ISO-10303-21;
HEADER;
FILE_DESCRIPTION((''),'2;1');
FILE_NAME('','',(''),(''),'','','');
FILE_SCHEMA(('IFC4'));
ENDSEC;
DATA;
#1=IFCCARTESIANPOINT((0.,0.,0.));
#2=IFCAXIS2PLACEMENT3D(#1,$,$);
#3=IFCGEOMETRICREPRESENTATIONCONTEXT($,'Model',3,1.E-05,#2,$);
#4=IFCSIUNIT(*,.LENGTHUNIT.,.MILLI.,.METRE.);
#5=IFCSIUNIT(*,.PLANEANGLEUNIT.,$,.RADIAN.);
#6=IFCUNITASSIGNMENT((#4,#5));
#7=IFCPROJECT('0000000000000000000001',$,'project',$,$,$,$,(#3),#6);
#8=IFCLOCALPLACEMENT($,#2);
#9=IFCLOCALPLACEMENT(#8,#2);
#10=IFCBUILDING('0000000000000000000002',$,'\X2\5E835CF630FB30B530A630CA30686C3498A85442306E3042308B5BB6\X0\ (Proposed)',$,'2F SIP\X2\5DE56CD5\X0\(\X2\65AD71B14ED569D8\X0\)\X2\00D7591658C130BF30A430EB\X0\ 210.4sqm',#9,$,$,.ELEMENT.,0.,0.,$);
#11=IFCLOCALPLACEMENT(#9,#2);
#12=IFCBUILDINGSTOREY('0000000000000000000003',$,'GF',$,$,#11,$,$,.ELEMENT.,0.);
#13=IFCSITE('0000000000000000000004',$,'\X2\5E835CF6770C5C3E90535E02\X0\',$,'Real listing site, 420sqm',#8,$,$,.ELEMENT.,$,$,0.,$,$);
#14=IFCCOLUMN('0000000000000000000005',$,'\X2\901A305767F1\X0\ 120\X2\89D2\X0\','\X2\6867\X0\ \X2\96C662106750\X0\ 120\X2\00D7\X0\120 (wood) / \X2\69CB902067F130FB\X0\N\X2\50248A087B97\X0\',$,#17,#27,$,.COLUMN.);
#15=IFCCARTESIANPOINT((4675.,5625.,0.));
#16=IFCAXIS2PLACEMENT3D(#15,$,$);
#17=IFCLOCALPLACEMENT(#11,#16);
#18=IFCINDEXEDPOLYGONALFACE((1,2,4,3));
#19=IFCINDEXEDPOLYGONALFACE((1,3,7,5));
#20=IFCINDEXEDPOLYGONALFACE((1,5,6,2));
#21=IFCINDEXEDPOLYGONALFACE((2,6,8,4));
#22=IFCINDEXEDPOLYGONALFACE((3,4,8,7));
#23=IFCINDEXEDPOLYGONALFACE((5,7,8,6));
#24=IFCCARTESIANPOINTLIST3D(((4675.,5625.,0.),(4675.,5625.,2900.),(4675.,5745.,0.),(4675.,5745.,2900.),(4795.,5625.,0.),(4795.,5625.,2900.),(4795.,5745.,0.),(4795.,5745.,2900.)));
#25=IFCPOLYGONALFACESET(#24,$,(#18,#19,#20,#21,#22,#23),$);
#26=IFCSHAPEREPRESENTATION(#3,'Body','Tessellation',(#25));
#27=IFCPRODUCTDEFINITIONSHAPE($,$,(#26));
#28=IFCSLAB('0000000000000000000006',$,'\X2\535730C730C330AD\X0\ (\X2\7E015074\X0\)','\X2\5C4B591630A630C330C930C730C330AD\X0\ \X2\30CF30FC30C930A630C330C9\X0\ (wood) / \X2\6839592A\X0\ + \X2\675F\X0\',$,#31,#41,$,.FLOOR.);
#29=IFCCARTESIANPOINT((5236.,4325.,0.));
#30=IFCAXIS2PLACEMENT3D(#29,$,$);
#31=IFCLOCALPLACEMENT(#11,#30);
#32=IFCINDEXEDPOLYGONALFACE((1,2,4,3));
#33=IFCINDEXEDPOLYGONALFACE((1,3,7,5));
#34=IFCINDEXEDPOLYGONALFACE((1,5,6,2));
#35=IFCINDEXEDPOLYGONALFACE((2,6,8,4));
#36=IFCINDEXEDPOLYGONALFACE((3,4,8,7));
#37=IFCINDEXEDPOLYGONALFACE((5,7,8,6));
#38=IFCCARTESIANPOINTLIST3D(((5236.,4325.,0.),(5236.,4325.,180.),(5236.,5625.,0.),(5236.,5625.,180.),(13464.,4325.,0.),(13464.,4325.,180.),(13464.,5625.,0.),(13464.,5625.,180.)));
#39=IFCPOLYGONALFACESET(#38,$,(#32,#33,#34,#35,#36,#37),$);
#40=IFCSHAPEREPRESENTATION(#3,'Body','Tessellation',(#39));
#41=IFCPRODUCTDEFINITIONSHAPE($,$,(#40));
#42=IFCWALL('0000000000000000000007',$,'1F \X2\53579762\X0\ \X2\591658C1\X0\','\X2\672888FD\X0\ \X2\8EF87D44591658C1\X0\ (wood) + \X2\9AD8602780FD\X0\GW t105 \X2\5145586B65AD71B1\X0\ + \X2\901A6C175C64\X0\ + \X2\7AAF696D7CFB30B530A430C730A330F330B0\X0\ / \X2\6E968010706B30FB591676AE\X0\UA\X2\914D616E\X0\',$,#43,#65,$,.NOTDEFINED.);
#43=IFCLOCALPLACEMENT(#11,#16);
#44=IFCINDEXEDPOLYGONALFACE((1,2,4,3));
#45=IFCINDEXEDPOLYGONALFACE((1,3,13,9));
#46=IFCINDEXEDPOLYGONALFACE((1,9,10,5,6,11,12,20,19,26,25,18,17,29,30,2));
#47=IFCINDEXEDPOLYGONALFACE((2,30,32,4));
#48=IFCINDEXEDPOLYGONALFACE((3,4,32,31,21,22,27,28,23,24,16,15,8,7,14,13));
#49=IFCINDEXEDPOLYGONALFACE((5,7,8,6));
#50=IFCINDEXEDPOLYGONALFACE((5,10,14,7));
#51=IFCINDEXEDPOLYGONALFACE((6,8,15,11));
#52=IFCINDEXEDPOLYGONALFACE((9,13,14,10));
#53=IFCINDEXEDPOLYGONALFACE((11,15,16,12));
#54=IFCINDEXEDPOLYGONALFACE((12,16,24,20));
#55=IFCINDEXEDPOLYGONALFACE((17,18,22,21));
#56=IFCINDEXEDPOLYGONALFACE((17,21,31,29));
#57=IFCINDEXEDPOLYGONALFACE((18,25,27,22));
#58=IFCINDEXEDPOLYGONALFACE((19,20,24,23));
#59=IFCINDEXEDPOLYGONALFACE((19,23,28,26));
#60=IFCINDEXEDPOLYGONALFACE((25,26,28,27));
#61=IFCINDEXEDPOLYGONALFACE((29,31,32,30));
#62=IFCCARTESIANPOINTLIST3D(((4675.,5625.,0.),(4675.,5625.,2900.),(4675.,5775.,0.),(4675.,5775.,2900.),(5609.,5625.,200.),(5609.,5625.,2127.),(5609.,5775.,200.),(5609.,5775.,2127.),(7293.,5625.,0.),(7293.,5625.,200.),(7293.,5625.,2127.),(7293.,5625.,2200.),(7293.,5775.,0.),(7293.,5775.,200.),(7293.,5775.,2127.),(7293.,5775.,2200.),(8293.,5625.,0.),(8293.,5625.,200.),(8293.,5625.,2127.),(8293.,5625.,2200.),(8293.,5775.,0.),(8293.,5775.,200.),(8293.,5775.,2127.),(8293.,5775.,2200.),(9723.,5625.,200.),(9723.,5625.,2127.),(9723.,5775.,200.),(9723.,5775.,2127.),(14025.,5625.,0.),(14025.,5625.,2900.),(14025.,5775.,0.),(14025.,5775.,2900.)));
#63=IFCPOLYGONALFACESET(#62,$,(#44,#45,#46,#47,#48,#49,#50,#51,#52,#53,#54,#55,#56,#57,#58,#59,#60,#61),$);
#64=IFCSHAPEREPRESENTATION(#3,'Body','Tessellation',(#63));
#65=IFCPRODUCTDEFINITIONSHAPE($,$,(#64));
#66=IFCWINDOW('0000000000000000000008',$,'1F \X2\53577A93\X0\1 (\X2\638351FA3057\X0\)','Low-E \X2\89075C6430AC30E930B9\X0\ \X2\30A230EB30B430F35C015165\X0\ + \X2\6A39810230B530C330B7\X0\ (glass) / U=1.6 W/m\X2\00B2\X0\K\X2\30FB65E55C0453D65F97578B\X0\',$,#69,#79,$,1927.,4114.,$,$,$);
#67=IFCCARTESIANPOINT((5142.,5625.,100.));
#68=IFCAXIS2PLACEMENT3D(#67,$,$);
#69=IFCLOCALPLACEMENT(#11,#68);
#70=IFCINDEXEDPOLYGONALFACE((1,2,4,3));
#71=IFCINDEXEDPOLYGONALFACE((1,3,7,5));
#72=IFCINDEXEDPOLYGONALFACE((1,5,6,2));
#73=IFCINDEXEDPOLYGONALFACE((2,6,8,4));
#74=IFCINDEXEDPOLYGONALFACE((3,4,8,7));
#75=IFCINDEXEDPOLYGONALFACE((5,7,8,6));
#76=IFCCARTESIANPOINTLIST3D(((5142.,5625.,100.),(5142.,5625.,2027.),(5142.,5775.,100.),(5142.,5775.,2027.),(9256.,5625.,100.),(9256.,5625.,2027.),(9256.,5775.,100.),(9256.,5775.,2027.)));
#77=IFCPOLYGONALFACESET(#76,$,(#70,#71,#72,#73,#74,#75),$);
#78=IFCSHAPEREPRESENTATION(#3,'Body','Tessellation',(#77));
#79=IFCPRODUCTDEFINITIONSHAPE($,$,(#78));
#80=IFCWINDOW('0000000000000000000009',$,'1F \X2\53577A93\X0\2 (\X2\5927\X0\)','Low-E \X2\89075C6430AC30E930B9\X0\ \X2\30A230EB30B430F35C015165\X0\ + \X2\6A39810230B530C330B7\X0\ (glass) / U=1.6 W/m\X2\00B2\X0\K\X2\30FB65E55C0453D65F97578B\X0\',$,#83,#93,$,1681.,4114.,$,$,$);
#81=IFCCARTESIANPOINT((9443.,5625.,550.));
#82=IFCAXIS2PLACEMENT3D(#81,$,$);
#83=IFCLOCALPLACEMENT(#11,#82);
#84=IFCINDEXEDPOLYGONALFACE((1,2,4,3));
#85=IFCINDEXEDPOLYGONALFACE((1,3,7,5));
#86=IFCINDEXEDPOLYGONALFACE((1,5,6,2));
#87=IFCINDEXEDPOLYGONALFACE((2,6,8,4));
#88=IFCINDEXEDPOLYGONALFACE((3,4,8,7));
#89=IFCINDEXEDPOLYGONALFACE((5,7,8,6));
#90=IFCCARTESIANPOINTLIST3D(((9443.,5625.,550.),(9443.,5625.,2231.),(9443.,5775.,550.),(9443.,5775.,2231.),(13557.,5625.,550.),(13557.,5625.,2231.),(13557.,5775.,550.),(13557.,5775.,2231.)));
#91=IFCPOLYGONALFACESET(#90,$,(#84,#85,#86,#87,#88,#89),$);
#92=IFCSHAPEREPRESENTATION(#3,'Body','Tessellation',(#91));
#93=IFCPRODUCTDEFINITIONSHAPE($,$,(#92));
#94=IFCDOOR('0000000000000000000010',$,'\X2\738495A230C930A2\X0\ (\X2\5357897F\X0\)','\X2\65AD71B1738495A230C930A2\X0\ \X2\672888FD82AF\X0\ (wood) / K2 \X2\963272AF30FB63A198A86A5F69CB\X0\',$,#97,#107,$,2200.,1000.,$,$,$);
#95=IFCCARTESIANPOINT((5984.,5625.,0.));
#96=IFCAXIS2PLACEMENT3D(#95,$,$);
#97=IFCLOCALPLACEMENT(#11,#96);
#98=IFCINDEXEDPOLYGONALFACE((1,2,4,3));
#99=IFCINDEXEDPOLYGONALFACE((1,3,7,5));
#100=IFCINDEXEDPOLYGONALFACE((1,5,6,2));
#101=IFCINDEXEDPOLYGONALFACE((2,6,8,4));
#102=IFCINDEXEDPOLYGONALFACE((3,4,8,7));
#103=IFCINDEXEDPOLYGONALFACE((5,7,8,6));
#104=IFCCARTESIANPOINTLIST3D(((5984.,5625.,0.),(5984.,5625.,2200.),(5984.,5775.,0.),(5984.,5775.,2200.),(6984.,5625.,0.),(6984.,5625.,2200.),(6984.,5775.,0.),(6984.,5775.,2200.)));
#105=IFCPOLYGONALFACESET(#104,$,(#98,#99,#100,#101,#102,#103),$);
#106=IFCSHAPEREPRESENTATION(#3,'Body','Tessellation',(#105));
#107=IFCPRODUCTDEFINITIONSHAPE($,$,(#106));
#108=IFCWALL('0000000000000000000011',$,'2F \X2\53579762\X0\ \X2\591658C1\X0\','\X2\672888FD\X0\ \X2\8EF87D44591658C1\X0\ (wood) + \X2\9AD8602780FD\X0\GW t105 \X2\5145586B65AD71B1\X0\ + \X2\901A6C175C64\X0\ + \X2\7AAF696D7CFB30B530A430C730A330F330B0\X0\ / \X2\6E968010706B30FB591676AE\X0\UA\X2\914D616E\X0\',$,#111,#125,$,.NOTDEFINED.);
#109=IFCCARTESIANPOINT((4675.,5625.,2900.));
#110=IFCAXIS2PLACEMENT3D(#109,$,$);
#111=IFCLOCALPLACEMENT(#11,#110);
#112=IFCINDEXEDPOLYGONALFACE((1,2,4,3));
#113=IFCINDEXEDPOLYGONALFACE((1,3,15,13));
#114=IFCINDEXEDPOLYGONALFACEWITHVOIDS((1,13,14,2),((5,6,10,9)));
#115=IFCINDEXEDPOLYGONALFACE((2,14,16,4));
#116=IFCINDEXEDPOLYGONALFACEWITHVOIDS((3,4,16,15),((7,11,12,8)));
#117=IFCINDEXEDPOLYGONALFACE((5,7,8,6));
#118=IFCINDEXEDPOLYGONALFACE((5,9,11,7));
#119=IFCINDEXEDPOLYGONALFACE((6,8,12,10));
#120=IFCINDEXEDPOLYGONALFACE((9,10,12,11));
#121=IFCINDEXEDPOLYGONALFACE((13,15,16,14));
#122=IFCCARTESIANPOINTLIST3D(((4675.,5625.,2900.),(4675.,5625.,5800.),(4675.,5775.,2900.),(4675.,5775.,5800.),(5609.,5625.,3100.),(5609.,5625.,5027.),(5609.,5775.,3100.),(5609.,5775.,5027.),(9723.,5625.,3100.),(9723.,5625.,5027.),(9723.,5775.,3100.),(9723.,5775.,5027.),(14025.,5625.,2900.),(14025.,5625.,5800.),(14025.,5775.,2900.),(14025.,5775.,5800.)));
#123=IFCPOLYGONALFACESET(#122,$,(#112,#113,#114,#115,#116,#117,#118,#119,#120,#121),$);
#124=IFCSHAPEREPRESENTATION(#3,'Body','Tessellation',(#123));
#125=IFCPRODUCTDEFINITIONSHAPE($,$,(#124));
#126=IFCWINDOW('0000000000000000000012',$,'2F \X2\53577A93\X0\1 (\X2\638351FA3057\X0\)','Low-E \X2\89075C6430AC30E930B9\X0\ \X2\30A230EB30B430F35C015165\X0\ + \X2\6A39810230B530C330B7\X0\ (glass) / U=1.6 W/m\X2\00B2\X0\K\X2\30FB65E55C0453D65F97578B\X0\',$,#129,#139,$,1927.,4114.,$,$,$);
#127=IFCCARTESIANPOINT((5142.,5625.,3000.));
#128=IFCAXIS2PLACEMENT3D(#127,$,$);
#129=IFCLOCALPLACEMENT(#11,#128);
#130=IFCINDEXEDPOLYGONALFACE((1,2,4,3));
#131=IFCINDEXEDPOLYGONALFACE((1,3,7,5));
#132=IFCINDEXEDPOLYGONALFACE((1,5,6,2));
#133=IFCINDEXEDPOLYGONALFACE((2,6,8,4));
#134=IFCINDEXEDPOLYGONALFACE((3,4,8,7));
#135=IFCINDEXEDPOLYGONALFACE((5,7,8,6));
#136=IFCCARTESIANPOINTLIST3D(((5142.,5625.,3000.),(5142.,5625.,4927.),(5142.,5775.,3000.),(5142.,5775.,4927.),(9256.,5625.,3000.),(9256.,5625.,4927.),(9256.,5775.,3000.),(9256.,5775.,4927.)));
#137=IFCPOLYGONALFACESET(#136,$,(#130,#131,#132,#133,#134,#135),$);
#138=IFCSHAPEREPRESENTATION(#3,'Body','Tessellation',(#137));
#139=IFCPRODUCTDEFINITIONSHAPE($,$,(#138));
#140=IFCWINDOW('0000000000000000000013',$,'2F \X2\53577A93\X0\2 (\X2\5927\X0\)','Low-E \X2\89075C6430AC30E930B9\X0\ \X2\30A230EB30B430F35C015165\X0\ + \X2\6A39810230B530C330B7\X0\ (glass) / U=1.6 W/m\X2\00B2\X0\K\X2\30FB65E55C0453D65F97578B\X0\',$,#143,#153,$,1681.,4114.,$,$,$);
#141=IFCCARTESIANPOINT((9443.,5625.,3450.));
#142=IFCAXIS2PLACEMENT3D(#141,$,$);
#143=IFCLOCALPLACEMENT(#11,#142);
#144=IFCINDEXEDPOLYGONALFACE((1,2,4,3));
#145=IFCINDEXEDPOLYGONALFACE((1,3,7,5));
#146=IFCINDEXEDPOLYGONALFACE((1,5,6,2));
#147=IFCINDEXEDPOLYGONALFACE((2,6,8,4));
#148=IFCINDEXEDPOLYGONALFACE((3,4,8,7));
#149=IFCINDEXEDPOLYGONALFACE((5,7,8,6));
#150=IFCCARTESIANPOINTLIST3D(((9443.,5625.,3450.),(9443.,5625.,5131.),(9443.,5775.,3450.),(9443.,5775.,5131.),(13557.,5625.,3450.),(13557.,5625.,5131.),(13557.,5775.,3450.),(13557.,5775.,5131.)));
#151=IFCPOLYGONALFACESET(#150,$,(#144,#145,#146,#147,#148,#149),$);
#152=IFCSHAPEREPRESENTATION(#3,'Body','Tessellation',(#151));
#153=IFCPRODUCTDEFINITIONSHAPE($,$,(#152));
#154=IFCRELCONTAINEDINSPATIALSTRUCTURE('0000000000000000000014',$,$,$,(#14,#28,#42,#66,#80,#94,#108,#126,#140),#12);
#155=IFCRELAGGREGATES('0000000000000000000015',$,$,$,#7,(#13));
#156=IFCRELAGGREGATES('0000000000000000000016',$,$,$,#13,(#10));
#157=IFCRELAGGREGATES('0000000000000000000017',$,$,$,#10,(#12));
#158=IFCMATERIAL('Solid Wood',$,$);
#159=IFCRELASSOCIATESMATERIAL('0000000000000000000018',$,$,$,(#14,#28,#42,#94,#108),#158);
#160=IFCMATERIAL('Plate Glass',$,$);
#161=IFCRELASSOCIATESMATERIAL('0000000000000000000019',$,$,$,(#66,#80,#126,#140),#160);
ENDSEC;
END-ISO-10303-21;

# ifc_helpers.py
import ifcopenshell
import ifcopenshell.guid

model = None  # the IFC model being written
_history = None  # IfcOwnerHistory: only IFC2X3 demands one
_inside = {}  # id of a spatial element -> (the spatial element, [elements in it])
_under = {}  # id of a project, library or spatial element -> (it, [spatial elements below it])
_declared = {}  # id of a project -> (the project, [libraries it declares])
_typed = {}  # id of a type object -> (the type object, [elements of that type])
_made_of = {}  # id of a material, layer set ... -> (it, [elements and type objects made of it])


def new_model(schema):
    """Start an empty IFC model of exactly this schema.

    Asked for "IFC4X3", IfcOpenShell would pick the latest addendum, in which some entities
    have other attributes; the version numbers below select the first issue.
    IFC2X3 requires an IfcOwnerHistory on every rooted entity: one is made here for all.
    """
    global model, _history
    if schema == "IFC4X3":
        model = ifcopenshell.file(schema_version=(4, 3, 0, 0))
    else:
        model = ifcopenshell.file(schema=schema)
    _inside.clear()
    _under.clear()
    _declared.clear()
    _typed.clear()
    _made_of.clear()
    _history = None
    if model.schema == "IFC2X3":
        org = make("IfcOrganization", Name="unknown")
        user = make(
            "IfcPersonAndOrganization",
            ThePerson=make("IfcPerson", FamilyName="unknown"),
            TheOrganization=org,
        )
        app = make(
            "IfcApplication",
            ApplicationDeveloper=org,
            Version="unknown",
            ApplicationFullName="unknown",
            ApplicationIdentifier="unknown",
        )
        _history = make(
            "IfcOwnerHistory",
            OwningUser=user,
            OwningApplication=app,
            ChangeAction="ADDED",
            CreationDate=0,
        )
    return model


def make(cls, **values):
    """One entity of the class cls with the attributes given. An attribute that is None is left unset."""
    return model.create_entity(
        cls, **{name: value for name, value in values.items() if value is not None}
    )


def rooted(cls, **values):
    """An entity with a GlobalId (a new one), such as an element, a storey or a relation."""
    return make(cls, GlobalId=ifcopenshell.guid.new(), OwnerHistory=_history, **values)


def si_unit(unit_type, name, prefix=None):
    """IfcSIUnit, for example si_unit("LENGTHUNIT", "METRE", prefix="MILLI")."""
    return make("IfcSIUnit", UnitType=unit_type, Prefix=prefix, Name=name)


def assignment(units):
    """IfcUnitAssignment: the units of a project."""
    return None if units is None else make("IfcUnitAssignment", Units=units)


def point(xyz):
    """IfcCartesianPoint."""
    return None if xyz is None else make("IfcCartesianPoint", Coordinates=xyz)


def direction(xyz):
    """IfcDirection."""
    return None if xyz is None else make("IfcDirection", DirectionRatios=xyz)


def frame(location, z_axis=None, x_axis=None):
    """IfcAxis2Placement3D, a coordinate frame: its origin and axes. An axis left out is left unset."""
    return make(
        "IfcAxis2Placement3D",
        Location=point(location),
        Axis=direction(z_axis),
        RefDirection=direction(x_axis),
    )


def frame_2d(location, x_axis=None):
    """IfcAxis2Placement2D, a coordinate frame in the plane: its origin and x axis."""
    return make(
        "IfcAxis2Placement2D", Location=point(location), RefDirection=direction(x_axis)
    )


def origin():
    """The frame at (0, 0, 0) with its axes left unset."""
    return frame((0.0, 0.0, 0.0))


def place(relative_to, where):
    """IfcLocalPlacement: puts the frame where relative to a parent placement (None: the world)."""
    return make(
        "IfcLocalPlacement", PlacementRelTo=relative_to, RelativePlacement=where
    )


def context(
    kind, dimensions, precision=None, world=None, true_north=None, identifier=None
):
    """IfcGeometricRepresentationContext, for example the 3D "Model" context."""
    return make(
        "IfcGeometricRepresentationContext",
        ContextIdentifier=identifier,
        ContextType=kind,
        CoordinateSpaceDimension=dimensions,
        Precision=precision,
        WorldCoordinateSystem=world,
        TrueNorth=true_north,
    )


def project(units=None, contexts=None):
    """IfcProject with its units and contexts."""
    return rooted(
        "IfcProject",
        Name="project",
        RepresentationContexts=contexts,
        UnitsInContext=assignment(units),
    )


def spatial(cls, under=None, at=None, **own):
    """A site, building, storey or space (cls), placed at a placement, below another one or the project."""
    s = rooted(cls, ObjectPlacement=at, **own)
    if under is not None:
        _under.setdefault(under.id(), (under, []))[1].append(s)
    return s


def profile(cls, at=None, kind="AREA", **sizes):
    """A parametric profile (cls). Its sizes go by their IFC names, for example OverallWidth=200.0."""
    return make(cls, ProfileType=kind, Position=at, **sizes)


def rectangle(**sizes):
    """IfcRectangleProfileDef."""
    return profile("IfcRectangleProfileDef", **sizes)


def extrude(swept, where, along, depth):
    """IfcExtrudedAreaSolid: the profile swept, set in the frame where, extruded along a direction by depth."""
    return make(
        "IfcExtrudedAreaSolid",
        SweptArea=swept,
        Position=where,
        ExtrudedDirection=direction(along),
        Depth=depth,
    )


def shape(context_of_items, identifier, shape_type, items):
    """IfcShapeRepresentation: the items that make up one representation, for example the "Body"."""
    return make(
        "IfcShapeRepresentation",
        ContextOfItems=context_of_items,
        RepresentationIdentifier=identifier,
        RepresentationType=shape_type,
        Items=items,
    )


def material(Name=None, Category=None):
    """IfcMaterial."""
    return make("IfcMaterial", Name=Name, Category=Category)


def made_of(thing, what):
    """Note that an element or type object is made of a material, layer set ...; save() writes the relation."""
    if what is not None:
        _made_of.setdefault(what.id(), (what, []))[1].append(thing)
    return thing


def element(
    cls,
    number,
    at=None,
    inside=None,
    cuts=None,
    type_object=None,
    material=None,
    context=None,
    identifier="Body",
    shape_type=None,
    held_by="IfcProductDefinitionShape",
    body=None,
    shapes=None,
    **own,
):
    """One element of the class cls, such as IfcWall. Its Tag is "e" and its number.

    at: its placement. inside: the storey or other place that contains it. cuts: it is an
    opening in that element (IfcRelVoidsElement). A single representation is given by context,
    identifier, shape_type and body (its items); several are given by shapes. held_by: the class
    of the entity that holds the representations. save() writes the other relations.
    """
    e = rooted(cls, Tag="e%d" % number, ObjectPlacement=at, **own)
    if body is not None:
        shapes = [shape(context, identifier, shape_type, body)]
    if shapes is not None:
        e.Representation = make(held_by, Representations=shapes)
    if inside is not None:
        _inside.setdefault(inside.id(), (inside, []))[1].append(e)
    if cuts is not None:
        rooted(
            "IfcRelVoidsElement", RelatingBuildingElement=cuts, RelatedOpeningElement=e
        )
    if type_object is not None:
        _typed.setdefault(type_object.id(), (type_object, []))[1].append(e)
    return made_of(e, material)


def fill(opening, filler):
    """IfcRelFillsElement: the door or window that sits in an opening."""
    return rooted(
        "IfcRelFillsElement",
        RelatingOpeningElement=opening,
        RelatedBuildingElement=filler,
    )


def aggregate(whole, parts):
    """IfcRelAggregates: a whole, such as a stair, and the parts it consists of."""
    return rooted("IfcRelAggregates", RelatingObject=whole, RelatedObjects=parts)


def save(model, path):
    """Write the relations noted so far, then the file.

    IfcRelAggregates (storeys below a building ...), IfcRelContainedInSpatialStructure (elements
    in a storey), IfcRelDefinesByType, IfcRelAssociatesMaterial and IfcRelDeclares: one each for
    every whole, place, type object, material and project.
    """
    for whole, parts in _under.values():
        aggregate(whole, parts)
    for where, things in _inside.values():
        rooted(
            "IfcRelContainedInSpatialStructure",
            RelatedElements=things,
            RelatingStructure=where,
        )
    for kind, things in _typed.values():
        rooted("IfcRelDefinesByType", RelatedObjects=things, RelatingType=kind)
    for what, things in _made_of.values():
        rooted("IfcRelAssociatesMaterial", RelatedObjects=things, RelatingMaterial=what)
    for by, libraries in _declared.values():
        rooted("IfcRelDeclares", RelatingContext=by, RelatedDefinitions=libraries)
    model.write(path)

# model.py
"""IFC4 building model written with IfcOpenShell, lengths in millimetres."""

from ifc_helpers import new_model, si_unit, frame, frame_2d, origin, place, context, project, spatial, rectangle, extrude, material, element, fill, save


model = new_model("IFC4")

# Units and contexts
model_context = context("Model", 3, precision=1e-05, world=origin())
ifc_project = project(units=[si_unit("LENGTHUNIT", "METRE", prefix="MILLI"), si_unit("PLANEANGLEUNIT", "RADIAN")], contexts=[model_context])

# Site, building, storey
site_placement = place(None, origin())
site = spatial("IfcSite", under=ifc_project, at=site_placement, Name="広島県尾道市", ObjectType="Real listing site, 420sqm", CompositionType="ELEMENT", RefElevation=0.0)
building_placement = place(site_placement, origin())
building = spatial("IfcBuilding", under=site, at=building_placement, Name="広島・サウナと水風呂のある家 (Proposed)", ObjectType="2F SIP工法(断熱仕様)×外壁タイル 210.4sqm", CompositionType="ELEMENT", ElevationOfRefHeight=0.0, ElevationOfTerrain=0.0)
storey_placement = place(building_placement, origin())
storey = spatial("IfcBuildingStorey", under=building, at=storey_placement, Name="GF", CompositionType="ELEMENT", Elevation=0.0)

# Column
ifc_material_1 = material(Name="Solid Wood")
column_placement = place(storey_placement, frame((4675.0, 5625.0, 0.0)))
element("IfcColumn", 1, at=column_placement, inside=storey, material=ifc_material_1, Name="通し柱 120角", Description="桧 集成材 120×120 (wood) / 構造柱・N値計算", PredefinedType="COLUMN", context=model_context, shape_type="SweptSolid", body=[
    extrude(rectangle(XDim=120.0, YDim=120.0, at=frame_2d((60.0, 60.0))), frame((4675.0, 5625.0, 0.0)), (0.0, 0.0, 1.0), 2900.0),
])

# Slab
slab_1_placement = place(storey_placement, frame((5236.0, 4325.0, 0.0)))
element("IfcSlab", 2, at=slab_1_placement, inside=storey, material=ifc_material_1, Name="南デッキ (縁側)", Description="屋外ウッドデッキ ハードウッド (wood) / 根太 + 束", PredefinedType="FLOOR", context=model_context, shape_type="SweptSolid", body=[
    extrude(rectangle(XDim=8228.0, YDim=1300.0, at=frame_2d((4114.0, 650.0))), frame((5236.0, 4325.0, 0.0)), (0.0, 0.0, 1.0), 180.0),
])

# Wall, openings, windows, door
wall_1_placement = place(storey_placement, frame((4675.0, 5625.0, 0.0)))
wall_1 = element("IfcWall", 3, at=wall_1_placement, inside=storey, material=ifc_material_1, Name="1F 南面 外壁", Description="木製 軸組外壁 (wood) + 高性能GW t105 充填断熱 + 通気層 + 窯業系サイディング / 準耐火・外皮UA配慮", PredefinedType="NOTDEFINED", context=model_context, shape_type="SweptSolid", body=[
    extrude(rectangle(XDim=9350.0, YDim=150.0, at=frame_2d((4675.0, 75.0))), frame((4675.0, 5625.0, 0.0)), (0.0, 0.0, 1.0), 2900.0),
])
opening_1_placement = place(storey_placement, frame((5142.0, 5625.0, 100.0)))
opening_1 = element("IfcOpeningElement", 4, at=opening_1_placement, cuts=wall_1, PredefinedType="NOTDEFINED", context=model_context, shape_type="SweptSolid", body=[
    extrude(rectangle(XDim=4114.0, YDim=150.0, at=frame_2d((2057.0, 75.0))), frame((5142.0, 5625.0, 100.0)), (0.0, 0.0, 1.0), 1927.0),
])
opening_2_placement = place(storey_placement, frame((9443.0, 5625.0, 550.0)))
opening_2 = element("IfcOpeningElement", 5, at=opening_2_placement, cuts=wall_1, PredefinedType="NOTDEFINED", context=model_context, shape_type="SweptSolid", body=[
    extrude(rectangle(XDim=4114.0, YDim=150.0, at=frame_2d((2057.0, 75.0))), frame((9443.0, 5625.0, 550.0)), (0.0, 0.0, 1.0), 1681.0),
])
opening_3_placement = place(storey_placement, frame((5984.0, 5625.0, 0.0)))
opening_3 = element("IfcOpeningElement", 6, at=opening_3_placement, cuts=wall_1, PredefinedType="NOTDEFINED", context=model_context, shape_type="SweptSolid", body=[
    extrude(rectangle(XDim=1000.0, YDim=150.0, at=frame_2d((500.0, 75.0))), frame((5984.0, 5625.0, 0.0)), (0.0, 0.0, 1.0), 2200.0),
])
ifc_material_2 = material(Name="Plate Glass")
window_1_placement = place(storey_placement, frame((5142.0, 5625.0, 100.0)))
window_1 = element("IfcWindow", 7, at=window_1_placement, inside=storey, material=ifc_material_2, Name="1F 南窓1 (掃出し)", Description="Low-E 複層ガラス アルゴン封入 + 樹脂サッシ (glass) / U=1.6 W/m²K・日射取得型", OverallHeight=1927.0, OverallWidth=4114.0, context=model_context, shape_type="SweptSolid", body=[
    extrude(rectangle(XDim=4114.0, YDim=150.0, at=frame_2d((2057.0, 75.0))), frame((5142.0, 5625.0, 100.0)), (0.0, 0.0, 1.0), 1927.0),
])
fill(opening_1, window_1)
window_2_placement = place(storey_placement, frame((9443.0, 5625.0, 550.0)))
window_2 = element("IfcWindow", 8, at=window_2_placement, inside=storey, material=ifc_material_2, Name="1F 南窓2 (大)", Description="Low-E 複層ガラス アルゴン封入 + 樹脂サッシ (glass) / U=1.6 W/m²K・日射取得型", OverallHeight=1681.0, OverallWidth=4114.0, context=model_context, shape_type="SweptSolid", body=[
    extrude(rectangle(XDim=4114.0, YDim=150.0, at=frame_2d((2057.0, 75.0))), frame((9443.0, 5625.0, 550.0)), (0.0, 0.0, 1.0), 1681.0),
])
fill(opening_2, window_2)
door_placement = place(storey_placement, frame((5984.0, 5625.0, 0.0)))
door = element("IfcDoor", 9, at=door_placement, inside=storey, material=ifc_material_1, Name="玄関ドア (南西)", Description="断熱玄関ドア 木製芯 (wood) / K2 防犯・採風機構", OverallHeight=2200.0, OverallWidth=1000.0, context=model_context, shape_type="SweptSolid", body=[
    extrude(rectangle(XDim=1000.0, YDim=150.0, at=frame_2d((500.0, 75.0))), frame((5984.0, 5625.0, 0.0)), (0.0, 0.0, 1.0), 2200.0),
])
fill(opening_3, door)

# Wall, openings, windows
wall_2_placement = place(storey_placement, frame((4675.0, 5625.0, 2900.0)))
wall_2 = element("IfcWall", 10, at=wall_2_placement, inside=storey, material=ifc_material_1, Name="2F 南面 外壁", Description="木製 軸組外壁 (wood) + 高性能GW t105 充填断熱 + 通気層 + 窯業系サイディング / 準耐火・外皮UA配慮", PredefinedType="NOTDEFINED", context=model_context, shape_type="SweptSolid", body=[
    extrude(rectangle(XDim=9350.0, YDim=150.0, at=frame_2d((4675.0, 75.0))), frame((4675.0, 5625.0, 2900.0)), (0.0, 0.0, 1.0), 2900.0),
])
opening_4_placement = place(storey_placement, frame((5142.0, 5625.0, 3000.0)))
opening_4 = element("IfcOpeningElement", 11, at=opening_4_placement, cuts=wall_2, PredefinedType="NOTDEFINED", context=model_context, shape_type="SweptSolid", body=[
    extrude(rectangle(XDim=4114.0, YDim=150.0, at=frame_2d((2057.0, 75.0))), frame((5142.0, 5625.0, 3000.0)), (0.0, 0.0, 1.0), 1927.0),
])
opening_5_placement = place(storey_placement, frame((9443.0, 5625.0, 3450.0)))
opening_5 = element("IfcOpeningElement", 12, at=opening_5_placement, cuts=wall_2, PredefinedType="NOTDEFINED", context=model_context, shape_type="SweptSolid", body=[
    extrude(rectangle(XDim=4114.0, YDim=150.0, at=frame_2d((2057.0, 75.0))), frame((9443.0, 5625.0, 3450.0)), (0.0, 0.0, 1.0), 1681.0),
])
window_3_placement = place(storey_placement, frame((5142.0, 5625.0, 3000.0)))
window_3 = element("IfcWindow", 13, at=window_3_placement, inside=storey, material=ifc_material_2, Name="2F 南窓1 (掃出し)", Description="Low-E 複層ガラス アルゴン封入 + 樹脂サッシ (glass) / U=1.6 W/m²K・日射取得型", OverallHeight=1927.0, OverallWidth=4114.0, context=model_context, shape_type="SweptSolid", body=[
    extrude(rectangle(XDim=4114.0, YDim=150.0, at=frame_2d((2057.0, 75.0))), frame((5142.0, 5625.0, 3000.0)), (0.0, 0.0, 1.0), 1927.0),
])
fill(opening_4, window_3)
window_4_placement = place(storey_placement, frame((9443.0, 5625.0, 3450.0)))
window_4 = element("IfcWindow", 14, at=window_4_placement, inside=storey, material=ifc_material_2, Name="2F 南窓2 (大)", Description="Low-E 複層ガラス アルゴン封入 + 樹脂サッシ (glass) / U=1.6 W/m²K・日射取得型", OverallHeight=1681.0, OverallWidth=4114.0, context=model_context, shape_type="SweptSolid", body=[
    extrude(rectangle(XDim=4114.0, YDim=150.0, at=frame_2d((2057.0, 75.0))), frame((9443.0, 5625.0, 3450.0)), (0.0, 0.0, 1.0), 1681.0),
])
fill(opening_5, window_4)

save(model, "model.ifc")
